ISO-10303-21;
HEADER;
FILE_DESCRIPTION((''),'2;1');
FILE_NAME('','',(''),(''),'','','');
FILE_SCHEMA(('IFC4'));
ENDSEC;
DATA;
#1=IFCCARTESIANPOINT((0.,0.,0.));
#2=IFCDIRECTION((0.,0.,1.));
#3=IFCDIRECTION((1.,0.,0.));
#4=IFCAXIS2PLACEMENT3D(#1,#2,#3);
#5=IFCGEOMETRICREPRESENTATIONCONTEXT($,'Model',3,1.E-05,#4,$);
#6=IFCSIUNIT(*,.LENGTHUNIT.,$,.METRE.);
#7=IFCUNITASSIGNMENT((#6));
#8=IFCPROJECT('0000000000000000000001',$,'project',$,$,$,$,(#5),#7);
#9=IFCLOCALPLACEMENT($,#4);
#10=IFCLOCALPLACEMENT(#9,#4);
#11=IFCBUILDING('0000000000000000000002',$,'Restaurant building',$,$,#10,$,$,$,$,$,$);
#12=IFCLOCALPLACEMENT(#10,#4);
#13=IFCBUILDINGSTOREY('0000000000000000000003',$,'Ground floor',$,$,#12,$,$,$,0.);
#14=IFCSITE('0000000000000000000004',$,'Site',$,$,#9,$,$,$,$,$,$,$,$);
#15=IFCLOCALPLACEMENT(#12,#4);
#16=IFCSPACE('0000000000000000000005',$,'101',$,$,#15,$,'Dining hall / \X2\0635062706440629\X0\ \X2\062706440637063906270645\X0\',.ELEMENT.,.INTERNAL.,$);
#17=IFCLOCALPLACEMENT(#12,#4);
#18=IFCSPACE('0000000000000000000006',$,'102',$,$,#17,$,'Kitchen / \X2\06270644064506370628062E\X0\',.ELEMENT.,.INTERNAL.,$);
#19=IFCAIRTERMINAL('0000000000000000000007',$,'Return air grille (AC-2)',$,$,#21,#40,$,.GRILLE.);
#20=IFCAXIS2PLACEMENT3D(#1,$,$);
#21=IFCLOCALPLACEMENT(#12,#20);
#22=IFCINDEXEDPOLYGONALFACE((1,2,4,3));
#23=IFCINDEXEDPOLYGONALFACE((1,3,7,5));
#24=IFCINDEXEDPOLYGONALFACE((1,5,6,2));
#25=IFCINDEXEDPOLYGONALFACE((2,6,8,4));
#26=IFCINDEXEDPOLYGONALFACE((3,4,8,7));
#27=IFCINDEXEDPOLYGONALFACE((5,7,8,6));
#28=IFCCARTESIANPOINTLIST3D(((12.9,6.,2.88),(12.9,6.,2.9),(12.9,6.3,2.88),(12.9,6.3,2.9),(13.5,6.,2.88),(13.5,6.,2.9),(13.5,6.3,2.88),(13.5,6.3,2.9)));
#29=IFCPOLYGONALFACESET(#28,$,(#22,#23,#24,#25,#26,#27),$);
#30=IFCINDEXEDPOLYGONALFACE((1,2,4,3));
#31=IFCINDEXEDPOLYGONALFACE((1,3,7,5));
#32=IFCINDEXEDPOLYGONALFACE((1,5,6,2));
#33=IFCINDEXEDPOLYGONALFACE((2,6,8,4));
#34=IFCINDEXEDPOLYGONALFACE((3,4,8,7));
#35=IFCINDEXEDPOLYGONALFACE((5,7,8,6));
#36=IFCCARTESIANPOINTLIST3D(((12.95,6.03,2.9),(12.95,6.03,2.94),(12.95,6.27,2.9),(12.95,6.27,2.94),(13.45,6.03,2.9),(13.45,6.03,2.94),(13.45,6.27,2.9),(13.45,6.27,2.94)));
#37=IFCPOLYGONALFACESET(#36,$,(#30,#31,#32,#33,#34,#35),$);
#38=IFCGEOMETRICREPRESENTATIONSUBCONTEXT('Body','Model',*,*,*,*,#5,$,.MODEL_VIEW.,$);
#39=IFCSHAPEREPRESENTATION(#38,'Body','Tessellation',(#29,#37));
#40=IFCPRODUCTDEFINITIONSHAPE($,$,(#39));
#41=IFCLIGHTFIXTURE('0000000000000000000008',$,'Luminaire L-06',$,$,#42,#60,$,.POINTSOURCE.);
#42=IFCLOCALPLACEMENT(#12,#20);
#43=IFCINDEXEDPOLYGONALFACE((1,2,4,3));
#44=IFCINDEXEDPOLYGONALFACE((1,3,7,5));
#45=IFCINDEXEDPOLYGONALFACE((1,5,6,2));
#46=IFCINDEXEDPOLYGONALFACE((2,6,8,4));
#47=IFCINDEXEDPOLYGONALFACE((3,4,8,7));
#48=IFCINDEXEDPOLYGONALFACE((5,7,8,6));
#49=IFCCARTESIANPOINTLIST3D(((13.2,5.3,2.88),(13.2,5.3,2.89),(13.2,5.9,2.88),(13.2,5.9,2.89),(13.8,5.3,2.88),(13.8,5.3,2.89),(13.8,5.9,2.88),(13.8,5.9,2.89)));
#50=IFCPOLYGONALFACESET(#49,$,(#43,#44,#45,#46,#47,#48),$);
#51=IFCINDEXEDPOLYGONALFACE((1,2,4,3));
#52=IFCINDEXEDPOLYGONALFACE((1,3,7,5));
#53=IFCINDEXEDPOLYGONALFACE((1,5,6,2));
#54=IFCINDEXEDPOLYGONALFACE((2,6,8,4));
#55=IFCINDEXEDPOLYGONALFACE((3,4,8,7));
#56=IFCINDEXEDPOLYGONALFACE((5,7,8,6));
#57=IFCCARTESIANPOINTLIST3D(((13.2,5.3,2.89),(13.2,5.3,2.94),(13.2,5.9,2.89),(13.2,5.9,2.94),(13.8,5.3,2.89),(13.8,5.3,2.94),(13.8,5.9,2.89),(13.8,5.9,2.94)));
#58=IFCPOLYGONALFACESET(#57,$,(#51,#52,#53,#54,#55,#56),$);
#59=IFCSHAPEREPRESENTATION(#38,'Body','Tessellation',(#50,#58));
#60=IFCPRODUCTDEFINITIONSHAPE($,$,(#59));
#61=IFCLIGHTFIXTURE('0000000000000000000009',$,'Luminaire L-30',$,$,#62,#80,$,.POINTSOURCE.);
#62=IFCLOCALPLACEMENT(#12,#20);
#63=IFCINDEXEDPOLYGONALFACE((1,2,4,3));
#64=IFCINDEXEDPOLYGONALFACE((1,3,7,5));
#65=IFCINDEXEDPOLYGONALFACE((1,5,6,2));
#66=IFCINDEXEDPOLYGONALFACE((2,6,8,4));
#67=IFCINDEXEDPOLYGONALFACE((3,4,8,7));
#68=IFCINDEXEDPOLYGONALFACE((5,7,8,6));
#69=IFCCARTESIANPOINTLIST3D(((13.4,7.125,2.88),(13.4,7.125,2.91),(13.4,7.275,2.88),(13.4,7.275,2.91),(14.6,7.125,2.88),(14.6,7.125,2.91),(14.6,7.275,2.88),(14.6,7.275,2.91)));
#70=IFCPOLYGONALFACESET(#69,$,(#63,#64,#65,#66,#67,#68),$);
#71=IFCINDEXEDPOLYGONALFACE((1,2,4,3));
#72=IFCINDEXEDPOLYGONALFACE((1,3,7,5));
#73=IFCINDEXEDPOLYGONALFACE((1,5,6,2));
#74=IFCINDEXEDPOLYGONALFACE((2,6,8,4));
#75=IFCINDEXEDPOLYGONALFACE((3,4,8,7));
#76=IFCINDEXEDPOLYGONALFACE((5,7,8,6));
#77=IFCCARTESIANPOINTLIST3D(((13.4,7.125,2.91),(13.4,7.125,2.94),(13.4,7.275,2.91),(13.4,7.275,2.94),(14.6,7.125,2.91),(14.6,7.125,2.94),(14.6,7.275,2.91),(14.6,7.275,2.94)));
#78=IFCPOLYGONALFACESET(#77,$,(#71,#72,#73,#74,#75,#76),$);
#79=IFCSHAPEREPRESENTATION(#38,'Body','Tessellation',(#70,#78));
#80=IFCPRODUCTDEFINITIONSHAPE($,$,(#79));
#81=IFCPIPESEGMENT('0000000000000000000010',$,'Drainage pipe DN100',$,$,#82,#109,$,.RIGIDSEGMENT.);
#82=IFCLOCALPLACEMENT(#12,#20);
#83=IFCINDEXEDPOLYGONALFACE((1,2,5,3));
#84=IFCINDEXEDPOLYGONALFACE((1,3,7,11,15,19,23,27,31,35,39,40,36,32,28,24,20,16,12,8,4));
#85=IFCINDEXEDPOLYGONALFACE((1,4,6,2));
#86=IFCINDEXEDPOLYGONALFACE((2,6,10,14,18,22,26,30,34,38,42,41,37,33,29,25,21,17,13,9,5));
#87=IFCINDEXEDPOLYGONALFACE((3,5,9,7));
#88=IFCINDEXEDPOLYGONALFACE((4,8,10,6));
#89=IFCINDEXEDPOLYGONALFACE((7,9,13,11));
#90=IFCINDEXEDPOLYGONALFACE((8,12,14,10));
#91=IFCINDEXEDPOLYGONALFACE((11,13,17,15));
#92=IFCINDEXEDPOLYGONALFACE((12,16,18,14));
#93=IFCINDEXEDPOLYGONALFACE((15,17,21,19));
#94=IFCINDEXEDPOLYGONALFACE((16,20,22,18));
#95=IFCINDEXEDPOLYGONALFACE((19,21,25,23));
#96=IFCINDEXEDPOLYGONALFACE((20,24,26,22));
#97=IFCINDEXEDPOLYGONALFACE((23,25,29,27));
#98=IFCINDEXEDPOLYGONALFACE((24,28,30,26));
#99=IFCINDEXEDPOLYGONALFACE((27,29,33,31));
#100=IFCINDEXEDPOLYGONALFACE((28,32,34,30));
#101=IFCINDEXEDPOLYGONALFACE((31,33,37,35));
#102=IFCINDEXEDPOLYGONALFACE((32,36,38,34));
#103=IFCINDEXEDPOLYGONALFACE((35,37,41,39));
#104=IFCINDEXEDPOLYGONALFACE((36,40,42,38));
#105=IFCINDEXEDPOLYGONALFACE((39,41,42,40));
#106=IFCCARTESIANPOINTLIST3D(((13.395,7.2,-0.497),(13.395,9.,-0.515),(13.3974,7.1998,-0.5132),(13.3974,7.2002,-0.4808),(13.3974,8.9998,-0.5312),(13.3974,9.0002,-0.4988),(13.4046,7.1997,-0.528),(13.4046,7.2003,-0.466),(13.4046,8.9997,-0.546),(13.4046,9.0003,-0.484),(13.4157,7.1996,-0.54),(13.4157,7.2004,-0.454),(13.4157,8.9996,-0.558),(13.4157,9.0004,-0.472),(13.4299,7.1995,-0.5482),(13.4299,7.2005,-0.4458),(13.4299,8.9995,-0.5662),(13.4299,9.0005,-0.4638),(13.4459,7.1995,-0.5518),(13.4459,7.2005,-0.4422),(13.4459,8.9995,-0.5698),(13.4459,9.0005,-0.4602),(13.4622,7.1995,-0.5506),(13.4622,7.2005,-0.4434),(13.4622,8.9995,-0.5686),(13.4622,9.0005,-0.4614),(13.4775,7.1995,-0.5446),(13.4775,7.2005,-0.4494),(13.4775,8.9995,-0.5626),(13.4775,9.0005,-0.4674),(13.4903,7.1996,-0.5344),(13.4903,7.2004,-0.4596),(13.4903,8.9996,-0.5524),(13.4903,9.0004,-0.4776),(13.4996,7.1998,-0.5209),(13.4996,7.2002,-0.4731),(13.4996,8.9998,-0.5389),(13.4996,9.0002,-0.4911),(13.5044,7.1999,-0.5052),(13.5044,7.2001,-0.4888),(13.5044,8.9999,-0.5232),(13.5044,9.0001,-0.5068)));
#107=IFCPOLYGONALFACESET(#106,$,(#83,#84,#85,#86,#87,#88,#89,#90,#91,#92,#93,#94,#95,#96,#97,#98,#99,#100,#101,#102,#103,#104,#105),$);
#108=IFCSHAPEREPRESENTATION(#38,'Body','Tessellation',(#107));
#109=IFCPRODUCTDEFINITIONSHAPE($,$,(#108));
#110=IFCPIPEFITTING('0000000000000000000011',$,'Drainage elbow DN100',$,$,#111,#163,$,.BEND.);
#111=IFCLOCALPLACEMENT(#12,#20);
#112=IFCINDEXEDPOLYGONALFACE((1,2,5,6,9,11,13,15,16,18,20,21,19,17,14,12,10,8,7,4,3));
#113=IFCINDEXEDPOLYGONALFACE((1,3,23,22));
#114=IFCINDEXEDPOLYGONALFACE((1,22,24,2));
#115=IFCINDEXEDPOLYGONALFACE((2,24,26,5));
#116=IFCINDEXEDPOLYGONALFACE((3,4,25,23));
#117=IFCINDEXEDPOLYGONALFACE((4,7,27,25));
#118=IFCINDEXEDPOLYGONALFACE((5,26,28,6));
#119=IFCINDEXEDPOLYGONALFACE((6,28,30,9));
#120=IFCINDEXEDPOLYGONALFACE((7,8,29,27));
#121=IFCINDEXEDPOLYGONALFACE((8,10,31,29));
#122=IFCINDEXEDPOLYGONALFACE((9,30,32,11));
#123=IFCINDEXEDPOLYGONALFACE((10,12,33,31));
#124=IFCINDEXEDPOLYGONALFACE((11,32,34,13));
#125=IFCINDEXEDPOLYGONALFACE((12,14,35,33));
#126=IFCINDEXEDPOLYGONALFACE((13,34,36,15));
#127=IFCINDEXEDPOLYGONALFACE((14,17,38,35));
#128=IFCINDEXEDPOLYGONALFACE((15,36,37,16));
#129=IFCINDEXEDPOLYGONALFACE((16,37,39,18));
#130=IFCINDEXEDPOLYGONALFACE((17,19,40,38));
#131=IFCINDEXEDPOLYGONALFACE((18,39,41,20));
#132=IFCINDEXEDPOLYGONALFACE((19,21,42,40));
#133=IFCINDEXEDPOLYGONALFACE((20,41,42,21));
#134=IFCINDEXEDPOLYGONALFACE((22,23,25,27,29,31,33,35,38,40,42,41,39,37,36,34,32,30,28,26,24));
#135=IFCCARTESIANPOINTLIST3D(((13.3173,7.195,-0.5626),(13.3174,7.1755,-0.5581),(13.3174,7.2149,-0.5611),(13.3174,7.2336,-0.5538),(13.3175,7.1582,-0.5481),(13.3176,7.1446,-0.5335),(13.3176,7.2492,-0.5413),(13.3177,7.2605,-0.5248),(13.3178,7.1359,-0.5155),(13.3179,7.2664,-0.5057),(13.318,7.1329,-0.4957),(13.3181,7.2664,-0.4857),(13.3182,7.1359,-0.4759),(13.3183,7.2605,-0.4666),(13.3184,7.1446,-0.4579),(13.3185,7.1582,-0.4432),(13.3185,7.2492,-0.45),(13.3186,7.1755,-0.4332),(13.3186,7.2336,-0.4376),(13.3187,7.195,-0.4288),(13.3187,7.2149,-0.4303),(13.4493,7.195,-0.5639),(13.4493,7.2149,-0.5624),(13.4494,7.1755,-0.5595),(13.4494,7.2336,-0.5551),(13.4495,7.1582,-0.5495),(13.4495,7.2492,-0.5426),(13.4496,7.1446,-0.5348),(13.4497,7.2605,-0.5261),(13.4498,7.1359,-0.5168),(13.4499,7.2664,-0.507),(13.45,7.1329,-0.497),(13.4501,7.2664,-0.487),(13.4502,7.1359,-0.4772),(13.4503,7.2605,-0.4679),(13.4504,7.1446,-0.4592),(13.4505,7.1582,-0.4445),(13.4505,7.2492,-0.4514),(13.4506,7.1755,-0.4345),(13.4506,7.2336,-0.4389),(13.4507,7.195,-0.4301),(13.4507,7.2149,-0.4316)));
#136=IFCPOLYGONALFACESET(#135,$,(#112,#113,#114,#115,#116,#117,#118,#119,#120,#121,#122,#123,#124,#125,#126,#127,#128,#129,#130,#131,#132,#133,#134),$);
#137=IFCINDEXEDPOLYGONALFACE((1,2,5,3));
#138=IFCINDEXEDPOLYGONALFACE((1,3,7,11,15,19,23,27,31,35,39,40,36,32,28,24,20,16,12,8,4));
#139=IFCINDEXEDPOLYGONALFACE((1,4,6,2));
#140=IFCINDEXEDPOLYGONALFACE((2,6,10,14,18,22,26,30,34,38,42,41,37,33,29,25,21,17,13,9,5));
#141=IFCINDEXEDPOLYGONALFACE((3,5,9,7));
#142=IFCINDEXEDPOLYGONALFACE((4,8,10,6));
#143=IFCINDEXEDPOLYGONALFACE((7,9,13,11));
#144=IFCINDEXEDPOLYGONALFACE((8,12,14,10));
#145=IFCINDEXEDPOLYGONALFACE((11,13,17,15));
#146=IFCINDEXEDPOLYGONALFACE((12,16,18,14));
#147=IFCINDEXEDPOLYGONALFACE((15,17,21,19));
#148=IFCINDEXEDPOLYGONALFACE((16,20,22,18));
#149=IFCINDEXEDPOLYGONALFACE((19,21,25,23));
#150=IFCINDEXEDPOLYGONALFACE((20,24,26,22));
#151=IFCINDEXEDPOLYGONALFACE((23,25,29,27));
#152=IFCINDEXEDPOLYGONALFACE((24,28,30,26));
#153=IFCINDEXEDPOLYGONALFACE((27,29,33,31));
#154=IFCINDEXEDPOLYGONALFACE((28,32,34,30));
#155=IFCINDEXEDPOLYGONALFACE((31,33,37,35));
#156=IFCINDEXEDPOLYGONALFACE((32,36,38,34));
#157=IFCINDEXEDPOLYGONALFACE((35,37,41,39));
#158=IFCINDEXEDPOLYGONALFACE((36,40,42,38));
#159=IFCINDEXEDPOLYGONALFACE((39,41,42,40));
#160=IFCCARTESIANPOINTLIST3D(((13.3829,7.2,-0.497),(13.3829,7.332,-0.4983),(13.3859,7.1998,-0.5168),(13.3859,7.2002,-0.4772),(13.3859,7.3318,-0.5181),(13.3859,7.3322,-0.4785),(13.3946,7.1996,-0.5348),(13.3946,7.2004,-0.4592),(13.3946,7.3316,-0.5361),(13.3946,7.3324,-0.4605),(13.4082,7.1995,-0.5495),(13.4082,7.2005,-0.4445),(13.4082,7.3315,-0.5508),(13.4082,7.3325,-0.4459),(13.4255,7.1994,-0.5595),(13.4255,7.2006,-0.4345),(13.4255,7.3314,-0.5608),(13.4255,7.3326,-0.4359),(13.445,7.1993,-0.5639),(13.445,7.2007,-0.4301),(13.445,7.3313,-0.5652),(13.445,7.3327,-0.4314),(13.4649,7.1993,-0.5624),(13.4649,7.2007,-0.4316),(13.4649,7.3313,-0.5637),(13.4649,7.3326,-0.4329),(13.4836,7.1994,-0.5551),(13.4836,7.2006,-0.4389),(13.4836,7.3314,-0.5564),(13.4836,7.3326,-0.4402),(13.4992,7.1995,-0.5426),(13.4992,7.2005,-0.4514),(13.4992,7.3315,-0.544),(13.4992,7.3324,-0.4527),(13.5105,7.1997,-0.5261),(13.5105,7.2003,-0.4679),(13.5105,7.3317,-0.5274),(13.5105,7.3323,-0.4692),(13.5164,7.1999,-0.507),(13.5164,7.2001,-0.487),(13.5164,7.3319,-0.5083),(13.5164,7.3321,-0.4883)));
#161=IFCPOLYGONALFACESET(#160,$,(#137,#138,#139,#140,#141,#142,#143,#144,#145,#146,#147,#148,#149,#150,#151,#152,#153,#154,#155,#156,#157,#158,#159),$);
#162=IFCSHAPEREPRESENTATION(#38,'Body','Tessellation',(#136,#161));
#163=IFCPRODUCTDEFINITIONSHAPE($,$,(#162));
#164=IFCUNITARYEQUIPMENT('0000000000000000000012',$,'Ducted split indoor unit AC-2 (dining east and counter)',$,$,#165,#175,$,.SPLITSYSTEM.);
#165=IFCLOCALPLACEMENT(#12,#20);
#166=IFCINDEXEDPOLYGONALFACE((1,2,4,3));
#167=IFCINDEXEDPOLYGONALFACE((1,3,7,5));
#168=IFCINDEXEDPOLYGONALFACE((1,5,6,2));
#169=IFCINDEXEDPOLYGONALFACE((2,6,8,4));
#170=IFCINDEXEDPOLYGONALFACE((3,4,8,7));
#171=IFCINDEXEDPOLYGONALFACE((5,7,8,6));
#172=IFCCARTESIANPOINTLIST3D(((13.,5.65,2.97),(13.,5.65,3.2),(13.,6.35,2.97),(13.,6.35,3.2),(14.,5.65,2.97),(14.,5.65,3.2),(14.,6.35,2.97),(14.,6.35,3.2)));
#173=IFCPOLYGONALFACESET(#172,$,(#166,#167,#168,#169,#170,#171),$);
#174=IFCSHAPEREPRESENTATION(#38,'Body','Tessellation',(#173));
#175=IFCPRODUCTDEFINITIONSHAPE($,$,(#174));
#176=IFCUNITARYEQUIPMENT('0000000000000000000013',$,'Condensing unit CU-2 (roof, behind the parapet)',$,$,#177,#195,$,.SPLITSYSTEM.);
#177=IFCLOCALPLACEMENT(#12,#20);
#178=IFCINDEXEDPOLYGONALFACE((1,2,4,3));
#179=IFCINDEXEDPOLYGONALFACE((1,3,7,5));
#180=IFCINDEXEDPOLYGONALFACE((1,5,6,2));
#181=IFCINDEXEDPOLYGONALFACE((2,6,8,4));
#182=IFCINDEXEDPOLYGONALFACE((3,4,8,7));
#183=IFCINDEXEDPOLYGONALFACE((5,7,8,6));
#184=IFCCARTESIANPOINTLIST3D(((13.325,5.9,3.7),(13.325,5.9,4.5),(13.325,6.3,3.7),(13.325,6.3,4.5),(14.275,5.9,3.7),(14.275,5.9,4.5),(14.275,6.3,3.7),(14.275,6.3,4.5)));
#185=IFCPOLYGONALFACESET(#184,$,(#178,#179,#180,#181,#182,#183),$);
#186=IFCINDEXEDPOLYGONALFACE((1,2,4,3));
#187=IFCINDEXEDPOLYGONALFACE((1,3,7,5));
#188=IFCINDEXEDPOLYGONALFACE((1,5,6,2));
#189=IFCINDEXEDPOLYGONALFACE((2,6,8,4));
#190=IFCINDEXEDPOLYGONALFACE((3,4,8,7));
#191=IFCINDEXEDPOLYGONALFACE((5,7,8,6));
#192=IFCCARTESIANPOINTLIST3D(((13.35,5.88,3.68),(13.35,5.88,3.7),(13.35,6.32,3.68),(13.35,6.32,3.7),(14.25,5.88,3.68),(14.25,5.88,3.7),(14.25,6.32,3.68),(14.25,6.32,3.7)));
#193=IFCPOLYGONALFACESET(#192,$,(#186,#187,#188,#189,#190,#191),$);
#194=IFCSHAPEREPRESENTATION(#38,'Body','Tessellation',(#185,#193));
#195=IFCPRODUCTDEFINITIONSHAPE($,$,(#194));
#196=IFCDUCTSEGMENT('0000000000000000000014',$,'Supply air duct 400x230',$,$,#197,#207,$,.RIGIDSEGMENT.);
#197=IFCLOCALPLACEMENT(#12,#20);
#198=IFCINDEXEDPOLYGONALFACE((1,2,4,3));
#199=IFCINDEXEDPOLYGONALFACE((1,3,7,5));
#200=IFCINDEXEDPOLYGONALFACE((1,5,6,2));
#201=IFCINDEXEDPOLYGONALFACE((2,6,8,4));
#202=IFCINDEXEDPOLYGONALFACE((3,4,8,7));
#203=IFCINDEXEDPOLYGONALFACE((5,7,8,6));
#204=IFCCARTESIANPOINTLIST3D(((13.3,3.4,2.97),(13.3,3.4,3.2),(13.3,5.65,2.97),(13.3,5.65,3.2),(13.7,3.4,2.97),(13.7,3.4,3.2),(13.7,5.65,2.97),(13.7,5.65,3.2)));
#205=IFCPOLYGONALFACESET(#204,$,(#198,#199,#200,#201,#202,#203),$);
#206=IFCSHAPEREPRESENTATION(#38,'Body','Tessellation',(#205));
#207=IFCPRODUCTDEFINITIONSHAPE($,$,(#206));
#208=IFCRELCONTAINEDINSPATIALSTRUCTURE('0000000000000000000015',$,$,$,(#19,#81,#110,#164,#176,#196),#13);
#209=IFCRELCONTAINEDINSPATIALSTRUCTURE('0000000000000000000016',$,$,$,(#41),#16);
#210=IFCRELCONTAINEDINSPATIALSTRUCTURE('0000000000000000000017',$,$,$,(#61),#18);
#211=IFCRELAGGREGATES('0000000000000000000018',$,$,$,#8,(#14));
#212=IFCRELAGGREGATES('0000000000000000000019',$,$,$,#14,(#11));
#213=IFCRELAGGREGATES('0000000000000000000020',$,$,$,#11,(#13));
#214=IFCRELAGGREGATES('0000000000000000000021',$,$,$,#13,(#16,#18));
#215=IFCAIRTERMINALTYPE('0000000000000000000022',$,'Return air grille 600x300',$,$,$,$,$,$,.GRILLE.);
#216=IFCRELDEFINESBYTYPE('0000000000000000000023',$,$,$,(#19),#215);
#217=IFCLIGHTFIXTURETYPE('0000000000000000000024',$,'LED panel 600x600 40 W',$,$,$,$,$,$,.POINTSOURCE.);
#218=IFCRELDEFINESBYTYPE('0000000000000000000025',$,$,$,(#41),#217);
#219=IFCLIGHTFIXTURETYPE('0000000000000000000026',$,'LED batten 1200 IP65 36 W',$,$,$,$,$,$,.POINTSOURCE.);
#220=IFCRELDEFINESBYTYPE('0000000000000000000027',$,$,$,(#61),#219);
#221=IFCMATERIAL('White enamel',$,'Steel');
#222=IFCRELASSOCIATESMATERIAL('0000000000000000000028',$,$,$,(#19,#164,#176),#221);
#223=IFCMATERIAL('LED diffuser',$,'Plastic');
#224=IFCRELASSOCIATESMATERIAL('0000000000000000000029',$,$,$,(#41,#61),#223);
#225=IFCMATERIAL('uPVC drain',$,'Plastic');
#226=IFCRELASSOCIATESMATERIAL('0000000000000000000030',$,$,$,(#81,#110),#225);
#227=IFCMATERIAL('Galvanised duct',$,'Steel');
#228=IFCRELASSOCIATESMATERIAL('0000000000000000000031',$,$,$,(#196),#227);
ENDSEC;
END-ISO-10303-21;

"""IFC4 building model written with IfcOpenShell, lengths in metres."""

from ifc_helpers import new_model, si_unit, frame, origin, origin_with_axes, origin_2d, place, context, subcontext, project, spatial, rectangle, circle, extrude, source, transform, mapped, material, type_object, type_shapes, element, save


model = new_model("IFC4")

# Units and contexts
model_context = context("Model", 3, precision=1e-05, world=origin_with_axes())
body_context = subcontext(model_context, "Body", "Model", "MODEL_VIEW")
ifc_project = project(units=[si_unit("LENGTHUNIT", "METRE")], contexts=[model_context])

# Site, building, storey
site_placement = place(None, origin_with_axes())
site = spatial("IfcSite", under=ifc_project, at=site_placement, Name="Site")
building_placement = place(site_placement, origin_with_axes())
building = spatial("IfcBuilding", under=site, at=building_placement, Name="Restaurant building")
storey_placement = place(building_placement, origin_with_axes())
storey = spatial("IfcBuildingStorey", under=building, at=storey_placement, Name="Ground floor", Elevation=0.0)

# Air terminal
ifc_material_1 = material(Name="White enamel", Category="Steel")
air_terminal_type = type_object("IfcAirTerminalType", Name="Return air grille 600x300", PredefinedType="GRILLE")
shared_shape_1 = source(origin(), body_context, "Body", "SweptSolid", [
    extrude(rectangle(XDim=0.6, YDim=0.3, at=origin_2d()), frame((0.0, 0.0, -0.06)), (0.0, 0.0, 1.0), 0.02),
    extrude(rectangle(XDim=0.5, YDim=0.24, at=origin_2d()), frame((0.0, 0.0, -0.04)), (0.0, 0.0, 1.0), 0.04),
])
type_shapes(air_terminal_type, [shared_shape_1])
air_terminal_placement = place(storey_placement, frame((13.2, 6.15, 2.94)))
element("IfcAirTerminal", 1, at=air_terminal_placement, inside=storey, type_object=air_terminal_type, material=ifc_material_1, Name="Return air grille (AC-2)", PredefinedType="GRILLE", context=body_context, shape_type="MappedRepresentation", body=[
    mapped(shared_shape_1, transform((0.0, 0.0, 0.0))),
])

# Shared definitions
space_1_placement = place(storey_placement, origin_with_axes())
space_1 = spatial("IfcSpace", under=storey, at=space_1_placement, Name="101", LongName="Dining hall / صالة الطعام", CompositionType="ELEMENT", PredefinedType="INTERNAL")

# Light fixture
ifc_material_2 = material(Name="LED diffuser", Category="Plastic")
light_fixture_type_1 = type_object("IfcLightFixtureType", Name="LED panel 600x600 40 W", PredefinedType="POINTSOURCE")
shared_shape_2 = source(origin(), body_context, "Body", "SweptSolid", [
    extrude(rectangle(XDim=0.6, YDim=0.6, at=origin_2d()), frame((0.0, 0.0, -0.06)), (0.0, 0.0, 1.0), 0.01),
    extrude(rectangle(XDim=0.6, YDim=0.6, at=origin_2d()), frame((0.0, 0.0, -0.05)), (0.0, 0.0, 1.0), 0.05),
])
type_shapes(light_fixture_type_1, [shared_shape_2])
light_fixture_1_placement = place(storey_placement, frame((13.5, 5.6, 2.94)))
element("IfcLightFixture", 2, at=light_fixture_1_placement, inside=space_1, type_object=light_fixture_type_1, material=ifc_material_2, Name="Luminaire L-06", PredefinedType="POINTSOURCE", context=body_context, shape_type="MappedRepresentation", body=[
    mapped(shared_shape_2, transform((0.0, 0.0, 0.0))),
])

# Shared definitions
space_2_placement = place(storey_placement, origin_with_axes())
space_2 = spatial("IfcSpace", under=storey, at=space_2_placement, Name="102", LongName="Kitchen / المطبخ", CompositionType="ELEMENT", PredefinedType="INTERNAL")

# Light fixture
light_fixture_type_2 = type_object("IfcLightFixtureType", Name="LED batten 1200 IP65 36 W", PredefinedType="POINTSOURCE")
shared_shape_3 = source(origin(), body_context, "Body", "SweptSolid", [
    extrude(rectangle(XDim=1.2, YDim=0.15, at=origin_2d()), frame((0.0, 0.0, -0.06)), (0.0, 0.0, 1.0), 0.03),
    extrude(rectangle(XDim=1.2, YDim=0.15, at=origin_2d()), frame((0.0, 0.0, -0.03)), (0.0, 0.0, 1.0), 0.03),
])
type_shapes(light_fixture_type_2, [shared_shape_3])
light_fixture_2_placement = place(storey_placement, frame((14.0, 7.2, 2.94)))
element("IfcLightFixture", 3, at=light_fixture_2_placement, inside=space_2, type_object=light_fixture_type_2, material=ifc_material_2, Name="Luminaire L-30", PredefinedType="POINTSOURCE", context=body_context, shape_type="MappedRepresentation", body=[
    mapped(shared_shape_3, transform((0.0, 0.0, 0.0))),
])

# Pipe segment
ifc_material_3 = material(Name="uPVC drain", Category="Plastic")
pipe_segment_1_placement = place(storey_placement, frame((13.45, 7.2, -0.497)))
element("IfcPipeSegment", 4, at=pipe_segment_1_placement, inside=storey, material=ifc_material_3, Name="Drainage pipe DN100", PredefinedType="RIGIDSEGMENT", context=body_context, shape_type="SweptSolid", body=[
    extrude(circle(Radius=0.055, at=origin_2d()), frame((0.0, 0.0, 0.0), z_axis=(0.0, 0.99995, -0.009999), x_axis=(-1.0, 0.0, 0.0)), (0.0, 0.0, 1.0), 1.8001),
])

# Pipe fitting
pipe_fitting_placement = place(storey_placement, frame((13.45, 7.2, -0.497)))
element("IfcPipeFitting", 5, at=pipe_fitting_placement, inside=storey, material=ifc_material_3, Name="Drainage elbow DN100", PredefinedType="BEND", context=body_context, shape_type="SweptSolid", body=[
    extrude(circle(Radius=0.0671, at=origin_2d()), frame((0.0, 0.0, 0.0), z_axis=(-0.99995, 0.0, 0.009999), x_axis=(0.0, -1.0, 0.0)), (0.0, 0.0, 1.0), 0.132),
    extrude(circle(Radius=0.0671, at=origin_2d()), frame((0.0, 0.0, 0.0), z_axis=(0.0, 0.99995, -0.009999), x_axis=(-1.0, 0.0, 0.0)), (0.0, 0.0, 1.0), 0.132),
])

# Unitary equipment
unitary_equipment_1_placement = place(storey_placement, frame((13.5, 6.0, 0.0)))
element("IfcUnitaryEquipment", 6, at=unitary_equipment_1_placement, inside=storey, material=ifc_material_1, Name="Ducted split indoor unit AC-2 (dining east and counter)", PredefinedType="SPLITSYSTEM", context=body_context, shape_type="SweptSolid", body=[
    extrude(rectangle(XDim=1.0, YDim=0.7, at=origin_2d()), frame((0.0, 0.0, 2.97)), (0.0, 0.0, 1.0), 0.23),
])
unitary_equipment_2_placement = place(storey_placement, frame((13.8, 6.1, 0.0)))
element("IfcUnitaryEquipment", 7, at=unitary_equipment_2_placement, inside=storey, material=ifc_material_1, Name="Condensing unit CU-2 (roof, behind the parapet)", PredefinedType="SPLITSYSTEM", context=body_context, shape_type="SweptSolid", body=[
    extrude(rectangle(XDim=0.95, YDim=0.4, at=origin_2d()), frame((0.0, 0.0, 3.7)), (0.0, 0.0, 1.0), 0.8),
    extrude(rectangle(XDim=0.9, YDim=0.44, at=origin_2d()), frame((0.0, 0.0, 3.68)), (0.0, 0.0, 1.0), 0.02),
])

# Duct segment
ifc_material_4 = material(Name="Galvanised duct", Category="Steel")
duct_segment_1_placement = place(storey_placement, frame((13.5, 5.65, 3.085)))
element("IfcDuctSegment", 8, at=duct_segment_1_placement, inside=storey, material=ifc_material_4, Name="Supply air duct 400x230", PredefinedType="RIGIDSEGMENT", context=body_context, shape_type="SweptSolid", body=[
    extrude(rectangle(XDim=0.4, YDim=0.23, at=origin_2d()), frame((0.0, 0.0, 0.0), z_axis=(0.0, -1.0, 0.0), x_axis=(1.0, 0.0, 0.0)), (0.0, 0.0, 1.0), 2.25),
])

save(model, "model.ifc")
